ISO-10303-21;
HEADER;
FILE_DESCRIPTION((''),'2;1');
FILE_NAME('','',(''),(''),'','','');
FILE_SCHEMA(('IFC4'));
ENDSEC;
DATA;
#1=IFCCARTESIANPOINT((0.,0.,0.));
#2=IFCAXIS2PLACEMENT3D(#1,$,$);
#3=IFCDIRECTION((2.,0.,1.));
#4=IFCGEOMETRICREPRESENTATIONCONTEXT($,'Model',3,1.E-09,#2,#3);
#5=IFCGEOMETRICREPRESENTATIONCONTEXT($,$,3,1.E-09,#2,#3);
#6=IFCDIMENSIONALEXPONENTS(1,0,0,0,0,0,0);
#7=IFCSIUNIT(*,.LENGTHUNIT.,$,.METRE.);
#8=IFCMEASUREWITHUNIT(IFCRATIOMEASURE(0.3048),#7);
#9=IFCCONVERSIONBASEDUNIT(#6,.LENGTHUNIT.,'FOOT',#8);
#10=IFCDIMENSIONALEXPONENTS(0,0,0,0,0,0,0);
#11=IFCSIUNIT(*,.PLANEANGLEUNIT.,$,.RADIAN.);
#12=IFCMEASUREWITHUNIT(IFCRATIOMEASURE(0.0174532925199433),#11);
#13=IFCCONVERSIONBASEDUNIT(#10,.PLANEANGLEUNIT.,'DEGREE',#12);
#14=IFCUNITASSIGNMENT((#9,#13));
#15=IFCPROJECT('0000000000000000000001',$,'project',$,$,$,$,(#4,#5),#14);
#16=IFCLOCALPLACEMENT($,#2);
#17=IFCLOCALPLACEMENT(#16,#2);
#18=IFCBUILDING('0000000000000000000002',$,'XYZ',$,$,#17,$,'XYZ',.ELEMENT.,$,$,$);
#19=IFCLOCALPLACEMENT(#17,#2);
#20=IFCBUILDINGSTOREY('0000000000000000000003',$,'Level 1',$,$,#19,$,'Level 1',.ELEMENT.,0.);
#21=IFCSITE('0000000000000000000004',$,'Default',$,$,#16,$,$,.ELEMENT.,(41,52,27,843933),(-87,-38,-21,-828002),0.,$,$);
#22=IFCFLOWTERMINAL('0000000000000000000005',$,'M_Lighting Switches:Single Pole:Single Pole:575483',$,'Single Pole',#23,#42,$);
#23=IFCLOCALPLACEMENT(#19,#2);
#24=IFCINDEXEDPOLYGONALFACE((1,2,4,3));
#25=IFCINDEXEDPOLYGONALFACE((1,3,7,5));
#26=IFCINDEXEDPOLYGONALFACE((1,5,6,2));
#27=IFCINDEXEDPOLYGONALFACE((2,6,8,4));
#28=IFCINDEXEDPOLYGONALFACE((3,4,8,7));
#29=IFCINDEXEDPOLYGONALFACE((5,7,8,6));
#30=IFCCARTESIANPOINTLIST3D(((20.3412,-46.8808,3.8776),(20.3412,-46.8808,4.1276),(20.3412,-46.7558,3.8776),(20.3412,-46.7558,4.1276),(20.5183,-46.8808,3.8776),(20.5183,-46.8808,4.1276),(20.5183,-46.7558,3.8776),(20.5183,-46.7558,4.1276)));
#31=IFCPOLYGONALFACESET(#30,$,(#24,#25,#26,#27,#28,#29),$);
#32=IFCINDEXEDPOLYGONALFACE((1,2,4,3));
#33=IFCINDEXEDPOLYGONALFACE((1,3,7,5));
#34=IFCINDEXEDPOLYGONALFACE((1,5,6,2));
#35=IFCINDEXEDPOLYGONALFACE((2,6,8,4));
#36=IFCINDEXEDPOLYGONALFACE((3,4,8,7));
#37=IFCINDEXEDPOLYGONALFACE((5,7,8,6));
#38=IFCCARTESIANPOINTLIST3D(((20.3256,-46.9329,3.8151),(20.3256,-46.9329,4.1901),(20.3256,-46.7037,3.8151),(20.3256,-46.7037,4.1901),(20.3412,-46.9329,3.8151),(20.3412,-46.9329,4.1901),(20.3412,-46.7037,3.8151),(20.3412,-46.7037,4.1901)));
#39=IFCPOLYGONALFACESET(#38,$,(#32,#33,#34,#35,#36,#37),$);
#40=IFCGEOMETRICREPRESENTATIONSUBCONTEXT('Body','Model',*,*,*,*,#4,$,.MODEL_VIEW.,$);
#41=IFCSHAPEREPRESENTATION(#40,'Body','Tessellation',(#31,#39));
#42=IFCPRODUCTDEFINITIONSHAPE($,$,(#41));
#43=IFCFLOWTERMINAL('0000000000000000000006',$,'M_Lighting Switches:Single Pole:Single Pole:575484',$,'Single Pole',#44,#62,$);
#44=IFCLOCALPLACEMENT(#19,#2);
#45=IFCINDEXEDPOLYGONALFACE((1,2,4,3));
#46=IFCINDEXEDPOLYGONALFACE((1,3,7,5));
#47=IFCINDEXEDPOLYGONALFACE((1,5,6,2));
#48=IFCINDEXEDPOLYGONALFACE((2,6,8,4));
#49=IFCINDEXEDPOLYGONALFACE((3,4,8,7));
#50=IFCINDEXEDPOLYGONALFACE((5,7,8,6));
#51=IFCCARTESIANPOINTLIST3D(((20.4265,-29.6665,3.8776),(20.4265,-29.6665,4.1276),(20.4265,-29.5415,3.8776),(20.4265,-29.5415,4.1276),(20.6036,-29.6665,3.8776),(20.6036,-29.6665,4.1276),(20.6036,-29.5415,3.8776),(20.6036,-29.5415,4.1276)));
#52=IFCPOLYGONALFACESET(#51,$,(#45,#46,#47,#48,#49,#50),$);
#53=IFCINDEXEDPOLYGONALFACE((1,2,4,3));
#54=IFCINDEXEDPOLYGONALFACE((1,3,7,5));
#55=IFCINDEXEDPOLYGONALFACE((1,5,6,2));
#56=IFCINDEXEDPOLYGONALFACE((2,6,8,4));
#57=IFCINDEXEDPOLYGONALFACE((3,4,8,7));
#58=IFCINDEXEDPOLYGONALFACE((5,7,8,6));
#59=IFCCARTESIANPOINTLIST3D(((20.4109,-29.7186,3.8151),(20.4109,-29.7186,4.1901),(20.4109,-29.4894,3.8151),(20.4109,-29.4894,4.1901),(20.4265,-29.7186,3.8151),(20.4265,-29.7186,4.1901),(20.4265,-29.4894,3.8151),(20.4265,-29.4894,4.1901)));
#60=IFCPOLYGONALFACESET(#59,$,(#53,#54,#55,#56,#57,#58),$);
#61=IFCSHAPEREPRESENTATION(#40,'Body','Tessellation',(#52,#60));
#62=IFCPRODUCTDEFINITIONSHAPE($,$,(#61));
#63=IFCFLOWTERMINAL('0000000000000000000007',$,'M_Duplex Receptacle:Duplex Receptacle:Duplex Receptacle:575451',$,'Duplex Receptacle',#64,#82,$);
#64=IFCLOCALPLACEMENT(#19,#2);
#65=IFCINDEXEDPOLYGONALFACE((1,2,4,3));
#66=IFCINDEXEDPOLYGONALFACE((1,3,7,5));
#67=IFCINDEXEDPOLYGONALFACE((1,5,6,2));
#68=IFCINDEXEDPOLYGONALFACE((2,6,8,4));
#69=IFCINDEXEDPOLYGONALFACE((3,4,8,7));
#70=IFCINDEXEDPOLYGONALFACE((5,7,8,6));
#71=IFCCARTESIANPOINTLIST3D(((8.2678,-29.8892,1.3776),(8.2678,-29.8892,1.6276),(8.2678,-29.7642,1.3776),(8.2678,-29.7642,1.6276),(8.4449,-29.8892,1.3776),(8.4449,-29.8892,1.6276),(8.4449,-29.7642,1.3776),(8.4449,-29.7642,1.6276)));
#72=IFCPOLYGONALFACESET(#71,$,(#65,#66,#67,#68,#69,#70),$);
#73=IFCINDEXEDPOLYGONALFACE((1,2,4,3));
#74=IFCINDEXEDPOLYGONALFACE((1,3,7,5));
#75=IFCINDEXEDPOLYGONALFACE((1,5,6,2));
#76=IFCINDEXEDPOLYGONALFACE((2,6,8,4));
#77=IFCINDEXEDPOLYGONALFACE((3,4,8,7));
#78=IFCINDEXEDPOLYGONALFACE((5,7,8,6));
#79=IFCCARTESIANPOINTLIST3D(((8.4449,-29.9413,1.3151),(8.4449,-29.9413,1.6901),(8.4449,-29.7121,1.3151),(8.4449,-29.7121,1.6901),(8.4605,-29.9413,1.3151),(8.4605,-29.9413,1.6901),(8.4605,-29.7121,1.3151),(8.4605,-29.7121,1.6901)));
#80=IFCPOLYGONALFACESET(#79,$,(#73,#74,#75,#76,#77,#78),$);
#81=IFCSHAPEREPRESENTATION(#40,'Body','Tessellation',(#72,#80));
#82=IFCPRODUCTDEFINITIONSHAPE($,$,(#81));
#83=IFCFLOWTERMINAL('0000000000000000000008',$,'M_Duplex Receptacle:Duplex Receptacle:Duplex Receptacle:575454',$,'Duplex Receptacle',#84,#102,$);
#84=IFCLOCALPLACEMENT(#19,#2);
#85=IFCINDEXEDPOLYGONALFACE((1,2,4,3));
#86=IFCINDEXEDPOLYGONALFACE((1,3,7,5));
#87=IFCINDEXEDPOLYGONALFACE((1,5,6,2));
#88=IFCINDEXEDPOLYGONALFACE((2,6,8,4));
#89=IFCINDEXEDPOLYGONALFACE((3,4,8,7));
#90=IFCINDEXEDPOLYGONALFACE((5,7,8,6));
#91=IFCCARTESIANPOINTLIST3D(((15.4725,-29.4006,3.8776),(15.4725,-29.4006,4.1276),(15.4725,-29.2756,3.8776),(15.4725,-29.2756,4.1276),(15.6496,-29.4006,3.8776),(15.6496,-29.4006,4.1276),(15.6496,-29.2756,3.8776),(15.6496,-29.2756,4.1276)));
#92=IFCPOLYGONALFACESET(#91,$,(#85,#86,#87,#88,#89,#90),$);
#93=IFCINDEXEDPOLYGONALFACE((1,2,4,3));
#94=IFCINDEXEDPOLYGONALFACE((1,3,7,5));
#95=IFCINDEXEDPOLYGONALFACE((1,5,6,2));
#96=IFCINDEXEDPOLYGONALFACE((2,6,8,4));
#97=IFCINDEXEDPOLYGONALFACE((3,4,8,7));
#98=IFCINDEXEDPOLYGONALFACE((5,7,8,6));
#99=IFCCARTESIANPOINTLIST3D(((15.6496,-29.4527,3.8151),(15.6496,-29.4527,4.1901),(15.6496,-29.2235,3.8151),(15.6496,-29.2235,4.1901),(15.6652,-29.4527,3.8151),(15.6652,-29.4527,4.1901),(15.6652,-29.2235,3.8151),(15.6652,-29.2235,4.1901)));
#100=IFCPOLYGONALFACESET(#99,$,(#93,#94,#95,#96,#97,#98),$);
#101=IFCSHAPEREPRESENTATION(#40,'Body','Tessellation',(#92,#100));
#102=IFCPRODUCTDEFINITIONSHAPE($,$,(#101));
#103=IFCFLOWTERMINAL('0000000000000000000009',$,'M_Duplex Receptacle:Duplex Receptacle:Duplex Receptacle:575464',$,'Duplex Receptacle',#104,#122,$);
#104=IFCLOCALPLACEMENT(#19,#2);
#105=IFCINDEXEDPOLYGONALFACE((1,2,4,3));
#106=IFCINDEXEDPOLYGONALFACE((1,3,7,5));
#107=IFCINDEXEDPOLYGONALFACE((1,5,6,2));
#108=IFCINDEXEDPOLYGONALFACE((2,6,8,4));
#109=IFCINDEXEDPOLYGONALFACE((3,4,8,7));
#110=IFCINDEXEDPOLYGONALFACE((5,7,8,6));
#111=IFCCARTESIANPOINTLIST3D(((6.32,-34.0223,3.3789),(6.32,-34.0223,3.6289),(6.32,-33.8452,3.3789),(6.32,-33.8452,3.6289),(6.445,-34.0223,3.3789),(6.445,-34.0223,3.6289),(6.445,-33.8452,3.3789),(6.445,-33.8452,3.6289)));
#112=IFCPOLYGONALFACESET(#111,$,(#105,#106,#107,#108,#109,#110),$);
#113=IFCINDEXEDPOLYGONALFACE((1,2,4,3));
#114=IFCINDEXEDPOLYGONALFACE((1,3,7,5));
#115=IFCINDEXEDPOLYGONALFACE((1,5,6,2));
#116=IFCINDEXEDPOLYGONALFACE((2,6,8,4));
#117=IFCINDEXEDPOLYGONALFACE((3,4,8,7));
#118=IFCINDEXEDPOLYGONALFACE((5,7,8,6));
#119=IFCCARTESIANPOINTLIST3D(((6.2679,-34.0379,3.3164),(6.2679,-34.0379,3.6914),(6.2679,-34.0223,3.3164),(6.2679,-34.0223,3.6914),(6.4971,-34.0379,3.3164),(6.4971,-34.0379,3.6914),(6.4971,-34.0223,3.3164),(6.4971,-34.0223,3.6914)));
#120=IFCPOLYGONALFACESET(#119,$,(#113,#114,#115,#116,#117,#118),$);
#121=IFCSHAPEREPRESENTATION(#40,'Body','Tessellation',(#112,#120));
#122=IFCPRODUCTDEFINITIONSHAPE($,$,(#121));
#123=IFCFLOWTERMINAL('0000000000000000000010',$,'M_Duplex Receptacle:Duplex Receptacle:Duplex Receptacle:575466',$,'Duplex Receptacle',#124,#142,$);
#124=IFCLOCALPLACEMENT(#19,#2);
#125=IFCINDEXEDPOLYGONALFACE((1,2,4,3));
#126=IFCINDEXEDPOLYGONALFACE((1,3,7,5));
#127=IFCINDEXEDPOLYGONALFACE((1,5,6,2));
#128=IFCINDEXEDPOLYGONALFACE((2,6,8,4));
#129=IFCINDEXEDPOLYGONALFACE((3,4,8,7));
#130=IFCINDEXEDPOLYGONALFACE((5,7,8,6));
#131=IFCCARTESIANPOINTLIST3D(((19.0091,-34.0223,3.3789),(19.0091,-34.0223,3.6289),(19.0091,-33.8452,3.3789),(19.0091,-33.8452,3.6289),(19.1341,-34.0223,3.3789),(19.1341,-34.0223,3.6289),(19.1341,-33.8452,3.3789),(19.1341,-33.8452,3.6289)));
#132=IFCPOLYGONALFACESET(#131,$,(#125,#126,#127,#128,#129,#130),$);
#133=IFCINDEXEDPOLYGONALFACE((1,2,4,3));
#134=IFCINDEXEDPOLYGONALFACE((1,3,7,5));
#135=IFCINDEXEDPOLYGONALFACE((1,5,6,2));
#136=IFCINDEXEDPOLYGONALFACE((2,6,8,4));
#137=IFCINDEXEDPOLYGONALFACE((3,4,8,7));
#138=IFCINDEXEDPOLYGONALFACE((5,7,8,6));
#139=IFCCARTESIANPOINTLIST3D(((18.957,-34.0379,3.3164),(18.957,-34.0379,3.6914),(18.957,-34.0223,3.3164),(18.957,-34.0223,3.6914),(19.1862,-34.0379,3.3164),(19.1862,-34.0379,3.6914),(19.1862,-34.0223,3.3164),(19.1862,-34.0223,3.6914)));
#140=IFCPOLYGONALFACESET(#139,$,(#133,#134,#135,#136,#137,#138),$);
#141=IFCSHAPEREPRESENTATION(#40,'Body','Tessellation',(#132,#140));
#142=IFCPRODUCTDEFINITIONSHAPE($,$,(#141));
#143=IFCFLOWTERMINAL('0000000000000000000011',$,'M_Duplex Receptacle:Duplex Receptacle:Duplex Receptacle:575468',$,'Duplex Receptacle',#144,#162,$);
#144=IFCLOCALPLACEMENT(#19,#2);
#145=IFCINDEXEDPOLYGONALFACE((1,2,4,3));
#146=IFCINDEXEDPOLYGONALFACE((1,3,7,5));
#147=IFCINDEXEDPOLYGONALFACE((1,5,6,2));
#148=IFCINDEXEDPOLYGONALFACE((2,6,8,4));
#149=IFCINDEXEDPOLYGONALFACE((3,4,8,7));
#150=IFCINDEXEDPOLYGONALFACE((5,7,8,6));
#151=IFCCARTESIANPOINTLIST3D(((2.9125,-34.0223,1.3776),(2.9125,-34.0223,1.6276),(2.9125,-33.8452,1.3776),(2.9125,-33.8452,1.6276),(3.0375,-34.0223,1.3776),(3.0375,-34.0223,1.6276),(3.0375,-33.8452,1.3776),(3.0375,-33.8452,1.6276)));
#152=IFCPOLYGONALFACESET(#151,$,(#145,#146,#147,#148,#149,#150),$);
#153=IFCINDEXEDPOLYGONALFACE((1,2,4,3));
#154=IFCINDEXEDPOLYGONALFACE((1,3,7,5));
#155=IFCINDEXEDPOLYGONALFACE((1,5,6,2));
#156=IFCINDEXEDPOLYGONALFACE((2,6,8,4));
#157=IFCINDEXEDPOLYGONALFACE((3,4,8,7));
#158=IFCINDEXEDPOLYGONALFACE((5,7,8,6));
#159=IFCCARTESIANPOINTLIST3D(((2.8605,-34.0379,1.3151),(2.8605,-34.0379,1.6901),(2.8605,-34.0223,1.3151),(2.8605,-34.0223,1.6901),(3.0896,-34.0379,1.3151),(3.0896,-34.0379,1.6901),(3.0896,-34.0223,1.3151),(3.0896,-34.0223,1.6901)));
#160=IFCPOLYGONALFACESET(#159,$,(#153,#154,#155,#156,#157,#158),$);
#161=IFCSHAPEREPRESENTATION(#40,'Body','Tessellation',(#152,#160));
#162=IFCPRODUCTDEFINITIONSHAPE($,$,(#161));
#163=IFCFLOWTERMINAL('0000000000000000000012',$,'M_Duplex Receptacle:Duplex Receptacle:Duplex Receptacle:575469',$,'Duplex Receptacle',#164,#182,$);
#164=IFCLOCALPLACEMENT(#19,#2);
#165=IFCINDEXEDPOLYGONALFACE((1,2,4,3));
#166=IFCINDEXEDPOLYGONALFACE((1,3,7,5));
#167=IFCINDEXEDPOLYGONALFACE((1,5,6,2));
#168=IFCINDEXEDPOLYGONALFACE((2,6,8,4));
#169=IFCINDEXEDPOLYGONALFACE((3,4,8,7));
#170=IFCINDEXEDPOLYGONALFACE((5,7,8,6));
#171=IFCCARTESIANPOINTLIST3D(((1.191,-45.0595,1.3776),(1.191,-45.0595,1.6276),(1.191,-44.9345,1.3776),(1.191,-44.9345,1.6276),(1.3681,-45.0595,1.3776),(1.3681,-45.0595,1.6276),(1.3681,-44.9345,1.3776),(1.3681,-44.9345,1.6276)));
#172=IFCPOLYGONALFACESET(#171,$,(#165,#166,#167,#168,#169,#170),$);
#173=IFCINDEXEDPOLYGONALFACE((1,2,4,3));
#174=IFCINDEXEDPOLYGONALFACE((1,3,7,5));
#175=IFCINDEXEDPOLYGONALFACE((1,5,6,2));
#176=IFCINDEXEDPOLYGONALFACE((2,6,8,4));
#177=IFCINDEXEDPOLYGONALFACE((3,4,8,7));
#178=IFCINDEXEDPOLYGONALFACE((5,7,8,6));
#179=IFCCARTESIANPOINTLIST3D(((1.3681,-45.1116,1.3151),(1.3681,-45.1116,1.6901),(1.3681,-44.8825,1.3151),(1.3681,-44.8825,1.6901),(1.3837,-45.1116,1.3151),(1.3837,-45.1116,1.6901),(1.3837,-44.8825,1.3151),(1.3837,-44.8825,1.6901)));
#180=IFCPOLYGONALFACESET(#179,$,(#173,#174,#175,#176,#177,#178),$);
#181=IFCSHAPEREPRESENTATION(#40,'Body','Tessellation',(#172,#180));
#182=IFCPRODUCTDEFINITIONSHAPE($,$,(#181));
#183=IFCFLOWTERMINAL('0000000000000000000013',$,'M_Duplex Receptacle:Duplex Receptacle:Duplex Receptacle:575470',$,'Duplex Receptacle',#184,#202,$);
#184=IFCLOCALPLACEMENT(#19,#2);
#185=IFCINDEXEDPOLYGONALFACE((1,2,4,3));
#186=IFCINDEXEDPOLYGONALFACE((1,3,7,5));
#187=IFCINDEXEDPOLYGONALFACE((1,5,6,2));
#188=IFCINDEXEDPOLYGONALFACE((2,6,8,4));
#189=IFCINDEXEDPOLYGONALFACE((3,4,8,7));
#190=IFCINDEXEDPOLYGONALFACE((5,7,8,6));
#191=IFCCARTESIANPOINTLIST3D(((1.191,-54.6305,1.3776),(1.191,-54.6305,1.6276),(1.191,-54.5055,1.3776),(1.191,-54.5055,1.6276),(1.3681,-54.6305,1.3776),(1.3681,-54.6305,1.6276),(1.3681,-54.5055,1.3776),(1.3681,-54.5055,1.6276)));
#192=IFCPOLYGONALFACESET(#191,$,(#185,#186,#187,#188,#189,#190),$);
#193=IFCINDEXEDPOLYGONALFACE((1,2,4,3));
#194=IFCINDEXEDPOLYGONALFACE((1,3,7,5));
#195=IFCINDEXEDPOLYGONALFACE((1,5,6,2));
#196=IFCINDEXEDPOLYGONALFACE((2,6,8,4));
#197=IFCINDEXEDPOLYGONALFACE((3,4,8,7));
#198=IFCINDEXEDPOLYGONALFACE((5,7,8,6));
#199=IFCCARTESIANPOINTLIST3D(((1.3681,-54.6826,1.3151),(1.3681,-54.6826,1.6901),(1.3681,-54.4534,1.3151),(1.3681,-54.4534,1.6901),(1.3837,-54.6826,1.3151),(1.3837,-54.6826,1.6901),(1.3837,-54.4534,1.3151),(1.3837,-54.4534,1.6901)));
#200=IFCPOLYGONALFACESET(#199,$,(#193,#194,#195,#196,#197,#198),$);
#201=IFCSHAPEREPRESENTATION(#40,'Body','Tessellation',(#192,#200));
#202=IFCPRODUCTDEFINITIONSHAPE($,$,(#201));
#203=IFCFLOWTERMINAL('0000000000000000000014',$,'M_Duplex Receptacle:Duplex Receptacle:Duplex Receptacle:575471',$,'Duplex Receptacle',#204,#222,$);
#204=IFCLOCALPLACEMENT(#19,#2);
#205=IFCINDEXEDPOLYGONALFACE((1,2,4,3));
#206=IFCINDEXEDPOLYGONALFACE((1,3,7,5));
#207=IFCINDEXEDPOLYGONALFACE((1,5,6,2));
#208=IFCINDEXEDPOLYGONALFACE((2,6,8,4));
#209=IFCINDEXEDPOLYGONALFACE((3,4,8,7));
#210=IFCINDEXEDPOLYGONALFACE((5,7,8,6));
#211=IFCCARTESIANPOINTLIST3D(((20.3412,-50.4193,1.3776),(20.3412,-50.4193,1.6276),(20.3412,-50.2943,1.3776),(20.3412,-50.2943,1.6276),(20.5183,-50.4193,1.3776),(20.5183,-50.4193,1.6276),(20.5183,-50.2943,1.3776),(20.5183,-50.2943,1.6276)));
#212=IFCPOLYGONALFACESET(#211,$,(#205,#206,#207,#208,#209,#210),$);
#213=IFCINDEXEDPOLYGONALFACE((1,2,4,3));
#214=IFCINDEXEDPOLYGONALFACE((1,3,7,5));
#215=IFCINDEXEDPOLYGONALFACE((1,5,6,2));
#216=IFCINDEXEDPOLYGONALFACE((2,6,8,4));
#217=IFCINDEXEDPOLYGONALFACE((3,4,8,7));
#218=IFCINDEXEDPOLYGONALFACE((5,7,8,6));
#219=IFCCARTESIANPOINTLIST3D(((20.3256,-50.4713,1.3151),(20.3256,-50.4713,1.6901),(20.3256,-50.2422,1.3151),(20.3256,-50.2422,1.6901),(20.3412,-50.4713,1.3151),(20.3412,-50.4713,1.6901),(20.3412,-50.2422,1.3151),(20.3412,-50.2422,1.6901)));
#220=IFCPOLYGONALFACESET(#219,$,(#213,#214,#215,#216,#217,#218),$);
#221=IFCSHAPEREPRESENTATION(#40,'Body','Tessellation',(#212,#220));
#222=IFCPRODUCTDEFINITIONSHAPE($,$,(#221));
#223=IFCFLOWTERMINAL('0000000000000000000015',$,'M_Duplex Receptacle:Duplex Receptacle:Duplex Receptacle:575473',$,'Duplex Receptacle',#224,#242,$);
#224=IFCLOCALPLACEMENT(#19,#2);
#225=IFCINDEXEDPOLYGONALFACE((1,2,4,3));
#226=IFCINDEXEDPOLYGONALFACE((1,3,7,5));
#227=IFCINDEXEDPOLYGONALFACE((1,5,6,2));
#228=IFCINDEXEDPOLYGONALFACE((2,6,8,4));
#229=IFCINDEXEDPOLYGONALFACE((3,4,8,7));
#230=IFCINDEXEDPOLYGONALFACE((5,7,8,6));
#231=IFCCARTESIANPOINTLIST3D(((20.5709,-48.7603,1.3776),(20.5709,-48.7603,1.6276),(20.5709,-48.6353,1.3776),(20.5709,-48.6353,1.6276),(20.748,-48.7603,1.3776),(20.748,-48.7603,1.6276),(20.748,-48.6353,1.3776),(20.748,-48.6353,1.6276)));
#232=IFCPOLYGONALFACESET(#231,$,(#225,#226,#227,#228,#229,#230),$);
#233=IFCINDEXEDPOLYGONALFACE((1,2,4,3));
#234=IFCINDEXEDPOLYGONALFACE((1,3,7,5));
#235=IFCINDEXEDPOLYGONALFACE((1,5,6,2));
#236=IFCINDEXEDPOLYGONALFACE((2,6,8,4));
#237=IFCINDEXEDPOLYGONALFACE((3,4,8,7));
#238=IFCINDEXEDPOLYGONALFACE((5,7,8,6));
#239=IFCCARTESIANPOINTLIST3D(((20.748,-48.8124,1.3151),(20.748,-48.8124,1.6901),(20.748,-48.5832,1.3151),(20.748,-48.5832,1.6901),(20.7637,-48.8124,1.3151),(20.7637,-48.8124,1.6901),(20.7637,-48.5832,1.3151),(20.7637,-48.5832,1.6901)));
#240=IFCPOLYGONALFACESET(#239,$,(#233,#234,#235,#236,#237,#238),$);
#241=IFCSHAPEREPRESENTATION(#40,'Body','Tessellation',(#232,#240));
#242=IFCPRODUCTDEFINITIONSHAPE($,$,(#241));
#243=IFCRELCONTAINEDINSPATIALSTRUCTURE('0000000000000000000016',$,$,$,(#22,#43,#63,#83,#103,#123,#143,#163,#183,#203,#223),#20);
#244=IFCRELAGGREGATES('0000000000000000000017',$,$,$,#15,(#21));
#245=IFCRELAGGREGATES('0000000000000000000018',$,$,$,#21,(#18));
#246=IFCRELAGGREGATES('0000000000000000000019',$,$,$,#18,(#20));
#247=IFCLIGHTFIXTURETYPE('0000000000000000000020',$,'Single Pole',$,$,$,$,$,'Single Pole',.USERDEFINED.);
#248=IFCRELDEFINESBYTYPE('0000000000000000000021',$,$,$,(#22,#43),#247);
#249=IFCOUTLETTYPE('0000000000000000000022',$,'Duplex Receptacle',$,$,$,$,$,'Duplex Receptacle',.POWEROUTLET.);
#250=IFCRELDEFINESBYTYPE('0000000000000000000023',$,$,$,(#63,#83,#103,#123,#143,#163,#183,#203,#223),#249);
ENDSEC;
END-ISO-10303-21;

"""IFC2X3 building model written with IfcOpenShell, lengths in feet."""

from ifc_helpers import new_model, entity, si_unit, converted_unit, direction, frame, frame_2d, origin, origin_2d_with_axis, place, context, subcontext, project, spatial, rectangle, extrude, source, transform, mapped, type_object, type_shapes, element, save


model = new_model("IFC2X3")

# Units and contexts
model_context = context("Model", 3, precision=1e-09, world=origin(), true_north=direction((2.0, 0.0, 1.0)))
context_of_model = context(None, 3, precision=1e-09, world=origin(), true_north=direction((2.0, 0.0, 1.0)))
body_context = subcontext(model_context, "Body", "Model", "MODEL_VIEW")
ifc_project = project(units=[converted_unit("LENGTHUNIT", "FOOT", entity("IfcRatioMeasure", 0.3048), si_unit("LENGTHUNIT", "METRE"), dimensions=[1, 0, 0, 0, 0, 0, 0]), converted_unit("PLANEANGLEUNIT", "DEGREE", entity("IfcRatioMeasure", 0.0174532925199433), si_unit("PLANEANGLEUNIT", "RADIAN"), dimensions=[0, 0, 0, 0, 0, 0, 0])], contexts=[model_context, context_of_model])

# Site, building, storey
site_placement = place(None, origin())
site = spatial("IfcSite", under=ifc_project, at=site_placement, Name="Default", CompositionType="ELEMENT", RefLatitude=(41, 52, 27, 843933), RefLongitude=(-87, -38, -21, -828002), RefElevation=0.0)
building_placement = place(site_placement, origin())
building = spatial("IfcBuilding", under=site, at=building_placement, Name="XYZ", LongName="XYZ", CompositionType="ELEMENT")
storey_placement = place(building_placement, origin())
storey = spatial("IfcBuildingStorey", under=building, at=storey_placement, Name="Level 1", LongName="Level 1", CompositionType="ELEMENT", Elevation=0.0)

# Flow terminals
light_fixture_type = type_object("IfcLightFixtureType", Name="Single Pole", ElementType="Single Pole", PredefinedType="USERDEFINED")
shared_shape_1 = source(origin(), body_context, "Body", "SweptSolid", [
    extrude(rectangle(XDim=0.125, YDim=0.25, at=origin_2d_with_axis()), frame((0.0, 0.0, -0.1771), z_axis=(0.0, 0.0, 1.0), x_axis=(-1.0, 0.0, 0.0)), (0.0, 0.0, 1.0), 0.1771),
    extrude(rectangle(XDim=0.2292, YDim=0.375, at=frame_2d((0.0, 0.0), x_axis=(1.0, 0.0))), frame((0.0, 0.0, 0.0), z_axis=(0.0, 0.0, 1.0), x_axis=(-1.0, 0.0, 0.0)), (0.0, 0.0, 1.0), 0.0156),
])
type_shapes(light_fixture_type, [shared_shape_1])
for number, where, z_axis, x_axis, name in (
    (1, (20.3412, -46.8183, 4.0026), (-1.0, 0.0, 0.0), (0.0, -1.0, 0.0), "M_Lighting Switches:Single Pole:Single Pole:575483"),
    (2, (20.4265, -29.604, 4.0026), (-1.0, 0.0, 0.0), (0.0, -1.0, 0.0), "M_Lighting Switches:Single Pole:Single Pole:575484"),
):
    element("IfcFlowTerminal", number, at=place(storey_placement, frame(where, z_axis=z_axis, x_axis=x_axis)), inside=storey, type_object=light_fixture_type, Name=name, ObjectType="Single Pole", context=body_context, shape_type="MappedRepresentation", body=[
        mapped(shared_shape_1, transform((0.0, 0.0, 0.0), scale=1.0)),
    ])
outlet_type = type_object("IfcOutletType", Name="Duplex Receptacle", ElementType="Duplex Receptacle", PredefinedType="POWEROUTLET")
shared_shape_2 = source(origin(), body_context, "Body", "SweptSolid", [
    extrude(rectangle(XDim=0.125, YDim=0.25, at=origin_2d_with_axis()), frame((0.0, 0.0, -0.1771), z_axis=(0.0, 0.0, 1.0), x_axis=(-1.0, 0.0, 0.0)), (0.0, 0.0, 1.0), 0.1771),
    extrude(rectangle(XDim=0.2292, YDim=0.375, at=frame_2d((0.0, 0.0), x_axis=(1.0, 0.0))), frame((0.0, 0.0, 0.0), z_axis=(0.0, 0.0, 1.0), x_axis=(-1.0, 0.0, 0.0)), (0.0, 0.0, 1.0), 0.0156),
])
type_shapes(outlet_type, [shared_shape_2])
for number, where, z_axis, x_axis, name in (
    (3, (8.4449, -29.8267, 1.5026), (1.0, 0.0, 0.0), (0.0, 1.0, 0.0), "M_Duplex Receptacle:Duplex Receptacle:Duplex Receptacle:575451"),
    (4, (15.6496, -29.3381, 4.0026), (1.0, 0.0, 0.0), (0.0, 1.0, 0.0), "M_Duplex Receptacle:Duplex Receptacle:Duplex Receptacle:575454"),
    (5, (6.3825, -34.0223, 3.5039), (0.0, -1.0, 0.0), (1.0, 0.0, 0.0), "M_Duplex Receptacle:Duplex Receptacle:Duplex Receptacle:575464"),
    (6, (19.0716, -34.0223, 3.5039), (0.0, -1.0, 0.0), (1.0, 0.0, 0.0), "M_Duplex Receptacle:Duplex Receptacle:Duplex Receptacle:575466"),
    (7, (2.975, -34.0223, 1.5026), (0.0, -1.0, 0.0), (1.0, 0.0, 0.0), "M_Duplex Receptacle:Duplex Receptacle:Duplex Receptacle:575468"),
    (8, (1.3681, -44.997, 1.5026), (1.0, 0.0, 0.0), (0.0, 1.0, 0.0), "M_Duplex Receptacle:Duplex Receptacle:Duplex Receptacle:575469"),
    (9, (1.3681, -54.568, 1.5026), (1.0, 0.0, 0.0), (0.0, 1.0, 0.0), "M_Duplex Receptacle:Duplex Receptacle:Duplex Receptacle:575470"),
    (10, (20.3412, -50.3568, 1.5026), (-1.0, 0.0, 0.0), (0.0, -1.0, 0.0), "M_Duplex Receptacle:Duplex Receptacle:Duplex Receptacle:575471"),
    (11, (20.748, -48.6978, 1.5026), (1.0, 0.0, 0.0), (0.0, 1.0, 0.0), "M_Duplex Receptacle:Duplex Receptacle:Duplex Receptacle:575473"),
):
    element("IfcFlowTerminal", number, at=place(storey_placement, frame(where, z_axis=z_axis, x_axis=x_axis)), inside=storey, type_object=outlet_type, Name=name, ObjectType="Duplex Receptacle", context=body_context, shape_type="MappedRepresentation", body=[
        mapped(shared_shape_2, transform((0.0, 0.0, 0.0), scale=1.0)),
    ])

save(model, "model.ifc")
